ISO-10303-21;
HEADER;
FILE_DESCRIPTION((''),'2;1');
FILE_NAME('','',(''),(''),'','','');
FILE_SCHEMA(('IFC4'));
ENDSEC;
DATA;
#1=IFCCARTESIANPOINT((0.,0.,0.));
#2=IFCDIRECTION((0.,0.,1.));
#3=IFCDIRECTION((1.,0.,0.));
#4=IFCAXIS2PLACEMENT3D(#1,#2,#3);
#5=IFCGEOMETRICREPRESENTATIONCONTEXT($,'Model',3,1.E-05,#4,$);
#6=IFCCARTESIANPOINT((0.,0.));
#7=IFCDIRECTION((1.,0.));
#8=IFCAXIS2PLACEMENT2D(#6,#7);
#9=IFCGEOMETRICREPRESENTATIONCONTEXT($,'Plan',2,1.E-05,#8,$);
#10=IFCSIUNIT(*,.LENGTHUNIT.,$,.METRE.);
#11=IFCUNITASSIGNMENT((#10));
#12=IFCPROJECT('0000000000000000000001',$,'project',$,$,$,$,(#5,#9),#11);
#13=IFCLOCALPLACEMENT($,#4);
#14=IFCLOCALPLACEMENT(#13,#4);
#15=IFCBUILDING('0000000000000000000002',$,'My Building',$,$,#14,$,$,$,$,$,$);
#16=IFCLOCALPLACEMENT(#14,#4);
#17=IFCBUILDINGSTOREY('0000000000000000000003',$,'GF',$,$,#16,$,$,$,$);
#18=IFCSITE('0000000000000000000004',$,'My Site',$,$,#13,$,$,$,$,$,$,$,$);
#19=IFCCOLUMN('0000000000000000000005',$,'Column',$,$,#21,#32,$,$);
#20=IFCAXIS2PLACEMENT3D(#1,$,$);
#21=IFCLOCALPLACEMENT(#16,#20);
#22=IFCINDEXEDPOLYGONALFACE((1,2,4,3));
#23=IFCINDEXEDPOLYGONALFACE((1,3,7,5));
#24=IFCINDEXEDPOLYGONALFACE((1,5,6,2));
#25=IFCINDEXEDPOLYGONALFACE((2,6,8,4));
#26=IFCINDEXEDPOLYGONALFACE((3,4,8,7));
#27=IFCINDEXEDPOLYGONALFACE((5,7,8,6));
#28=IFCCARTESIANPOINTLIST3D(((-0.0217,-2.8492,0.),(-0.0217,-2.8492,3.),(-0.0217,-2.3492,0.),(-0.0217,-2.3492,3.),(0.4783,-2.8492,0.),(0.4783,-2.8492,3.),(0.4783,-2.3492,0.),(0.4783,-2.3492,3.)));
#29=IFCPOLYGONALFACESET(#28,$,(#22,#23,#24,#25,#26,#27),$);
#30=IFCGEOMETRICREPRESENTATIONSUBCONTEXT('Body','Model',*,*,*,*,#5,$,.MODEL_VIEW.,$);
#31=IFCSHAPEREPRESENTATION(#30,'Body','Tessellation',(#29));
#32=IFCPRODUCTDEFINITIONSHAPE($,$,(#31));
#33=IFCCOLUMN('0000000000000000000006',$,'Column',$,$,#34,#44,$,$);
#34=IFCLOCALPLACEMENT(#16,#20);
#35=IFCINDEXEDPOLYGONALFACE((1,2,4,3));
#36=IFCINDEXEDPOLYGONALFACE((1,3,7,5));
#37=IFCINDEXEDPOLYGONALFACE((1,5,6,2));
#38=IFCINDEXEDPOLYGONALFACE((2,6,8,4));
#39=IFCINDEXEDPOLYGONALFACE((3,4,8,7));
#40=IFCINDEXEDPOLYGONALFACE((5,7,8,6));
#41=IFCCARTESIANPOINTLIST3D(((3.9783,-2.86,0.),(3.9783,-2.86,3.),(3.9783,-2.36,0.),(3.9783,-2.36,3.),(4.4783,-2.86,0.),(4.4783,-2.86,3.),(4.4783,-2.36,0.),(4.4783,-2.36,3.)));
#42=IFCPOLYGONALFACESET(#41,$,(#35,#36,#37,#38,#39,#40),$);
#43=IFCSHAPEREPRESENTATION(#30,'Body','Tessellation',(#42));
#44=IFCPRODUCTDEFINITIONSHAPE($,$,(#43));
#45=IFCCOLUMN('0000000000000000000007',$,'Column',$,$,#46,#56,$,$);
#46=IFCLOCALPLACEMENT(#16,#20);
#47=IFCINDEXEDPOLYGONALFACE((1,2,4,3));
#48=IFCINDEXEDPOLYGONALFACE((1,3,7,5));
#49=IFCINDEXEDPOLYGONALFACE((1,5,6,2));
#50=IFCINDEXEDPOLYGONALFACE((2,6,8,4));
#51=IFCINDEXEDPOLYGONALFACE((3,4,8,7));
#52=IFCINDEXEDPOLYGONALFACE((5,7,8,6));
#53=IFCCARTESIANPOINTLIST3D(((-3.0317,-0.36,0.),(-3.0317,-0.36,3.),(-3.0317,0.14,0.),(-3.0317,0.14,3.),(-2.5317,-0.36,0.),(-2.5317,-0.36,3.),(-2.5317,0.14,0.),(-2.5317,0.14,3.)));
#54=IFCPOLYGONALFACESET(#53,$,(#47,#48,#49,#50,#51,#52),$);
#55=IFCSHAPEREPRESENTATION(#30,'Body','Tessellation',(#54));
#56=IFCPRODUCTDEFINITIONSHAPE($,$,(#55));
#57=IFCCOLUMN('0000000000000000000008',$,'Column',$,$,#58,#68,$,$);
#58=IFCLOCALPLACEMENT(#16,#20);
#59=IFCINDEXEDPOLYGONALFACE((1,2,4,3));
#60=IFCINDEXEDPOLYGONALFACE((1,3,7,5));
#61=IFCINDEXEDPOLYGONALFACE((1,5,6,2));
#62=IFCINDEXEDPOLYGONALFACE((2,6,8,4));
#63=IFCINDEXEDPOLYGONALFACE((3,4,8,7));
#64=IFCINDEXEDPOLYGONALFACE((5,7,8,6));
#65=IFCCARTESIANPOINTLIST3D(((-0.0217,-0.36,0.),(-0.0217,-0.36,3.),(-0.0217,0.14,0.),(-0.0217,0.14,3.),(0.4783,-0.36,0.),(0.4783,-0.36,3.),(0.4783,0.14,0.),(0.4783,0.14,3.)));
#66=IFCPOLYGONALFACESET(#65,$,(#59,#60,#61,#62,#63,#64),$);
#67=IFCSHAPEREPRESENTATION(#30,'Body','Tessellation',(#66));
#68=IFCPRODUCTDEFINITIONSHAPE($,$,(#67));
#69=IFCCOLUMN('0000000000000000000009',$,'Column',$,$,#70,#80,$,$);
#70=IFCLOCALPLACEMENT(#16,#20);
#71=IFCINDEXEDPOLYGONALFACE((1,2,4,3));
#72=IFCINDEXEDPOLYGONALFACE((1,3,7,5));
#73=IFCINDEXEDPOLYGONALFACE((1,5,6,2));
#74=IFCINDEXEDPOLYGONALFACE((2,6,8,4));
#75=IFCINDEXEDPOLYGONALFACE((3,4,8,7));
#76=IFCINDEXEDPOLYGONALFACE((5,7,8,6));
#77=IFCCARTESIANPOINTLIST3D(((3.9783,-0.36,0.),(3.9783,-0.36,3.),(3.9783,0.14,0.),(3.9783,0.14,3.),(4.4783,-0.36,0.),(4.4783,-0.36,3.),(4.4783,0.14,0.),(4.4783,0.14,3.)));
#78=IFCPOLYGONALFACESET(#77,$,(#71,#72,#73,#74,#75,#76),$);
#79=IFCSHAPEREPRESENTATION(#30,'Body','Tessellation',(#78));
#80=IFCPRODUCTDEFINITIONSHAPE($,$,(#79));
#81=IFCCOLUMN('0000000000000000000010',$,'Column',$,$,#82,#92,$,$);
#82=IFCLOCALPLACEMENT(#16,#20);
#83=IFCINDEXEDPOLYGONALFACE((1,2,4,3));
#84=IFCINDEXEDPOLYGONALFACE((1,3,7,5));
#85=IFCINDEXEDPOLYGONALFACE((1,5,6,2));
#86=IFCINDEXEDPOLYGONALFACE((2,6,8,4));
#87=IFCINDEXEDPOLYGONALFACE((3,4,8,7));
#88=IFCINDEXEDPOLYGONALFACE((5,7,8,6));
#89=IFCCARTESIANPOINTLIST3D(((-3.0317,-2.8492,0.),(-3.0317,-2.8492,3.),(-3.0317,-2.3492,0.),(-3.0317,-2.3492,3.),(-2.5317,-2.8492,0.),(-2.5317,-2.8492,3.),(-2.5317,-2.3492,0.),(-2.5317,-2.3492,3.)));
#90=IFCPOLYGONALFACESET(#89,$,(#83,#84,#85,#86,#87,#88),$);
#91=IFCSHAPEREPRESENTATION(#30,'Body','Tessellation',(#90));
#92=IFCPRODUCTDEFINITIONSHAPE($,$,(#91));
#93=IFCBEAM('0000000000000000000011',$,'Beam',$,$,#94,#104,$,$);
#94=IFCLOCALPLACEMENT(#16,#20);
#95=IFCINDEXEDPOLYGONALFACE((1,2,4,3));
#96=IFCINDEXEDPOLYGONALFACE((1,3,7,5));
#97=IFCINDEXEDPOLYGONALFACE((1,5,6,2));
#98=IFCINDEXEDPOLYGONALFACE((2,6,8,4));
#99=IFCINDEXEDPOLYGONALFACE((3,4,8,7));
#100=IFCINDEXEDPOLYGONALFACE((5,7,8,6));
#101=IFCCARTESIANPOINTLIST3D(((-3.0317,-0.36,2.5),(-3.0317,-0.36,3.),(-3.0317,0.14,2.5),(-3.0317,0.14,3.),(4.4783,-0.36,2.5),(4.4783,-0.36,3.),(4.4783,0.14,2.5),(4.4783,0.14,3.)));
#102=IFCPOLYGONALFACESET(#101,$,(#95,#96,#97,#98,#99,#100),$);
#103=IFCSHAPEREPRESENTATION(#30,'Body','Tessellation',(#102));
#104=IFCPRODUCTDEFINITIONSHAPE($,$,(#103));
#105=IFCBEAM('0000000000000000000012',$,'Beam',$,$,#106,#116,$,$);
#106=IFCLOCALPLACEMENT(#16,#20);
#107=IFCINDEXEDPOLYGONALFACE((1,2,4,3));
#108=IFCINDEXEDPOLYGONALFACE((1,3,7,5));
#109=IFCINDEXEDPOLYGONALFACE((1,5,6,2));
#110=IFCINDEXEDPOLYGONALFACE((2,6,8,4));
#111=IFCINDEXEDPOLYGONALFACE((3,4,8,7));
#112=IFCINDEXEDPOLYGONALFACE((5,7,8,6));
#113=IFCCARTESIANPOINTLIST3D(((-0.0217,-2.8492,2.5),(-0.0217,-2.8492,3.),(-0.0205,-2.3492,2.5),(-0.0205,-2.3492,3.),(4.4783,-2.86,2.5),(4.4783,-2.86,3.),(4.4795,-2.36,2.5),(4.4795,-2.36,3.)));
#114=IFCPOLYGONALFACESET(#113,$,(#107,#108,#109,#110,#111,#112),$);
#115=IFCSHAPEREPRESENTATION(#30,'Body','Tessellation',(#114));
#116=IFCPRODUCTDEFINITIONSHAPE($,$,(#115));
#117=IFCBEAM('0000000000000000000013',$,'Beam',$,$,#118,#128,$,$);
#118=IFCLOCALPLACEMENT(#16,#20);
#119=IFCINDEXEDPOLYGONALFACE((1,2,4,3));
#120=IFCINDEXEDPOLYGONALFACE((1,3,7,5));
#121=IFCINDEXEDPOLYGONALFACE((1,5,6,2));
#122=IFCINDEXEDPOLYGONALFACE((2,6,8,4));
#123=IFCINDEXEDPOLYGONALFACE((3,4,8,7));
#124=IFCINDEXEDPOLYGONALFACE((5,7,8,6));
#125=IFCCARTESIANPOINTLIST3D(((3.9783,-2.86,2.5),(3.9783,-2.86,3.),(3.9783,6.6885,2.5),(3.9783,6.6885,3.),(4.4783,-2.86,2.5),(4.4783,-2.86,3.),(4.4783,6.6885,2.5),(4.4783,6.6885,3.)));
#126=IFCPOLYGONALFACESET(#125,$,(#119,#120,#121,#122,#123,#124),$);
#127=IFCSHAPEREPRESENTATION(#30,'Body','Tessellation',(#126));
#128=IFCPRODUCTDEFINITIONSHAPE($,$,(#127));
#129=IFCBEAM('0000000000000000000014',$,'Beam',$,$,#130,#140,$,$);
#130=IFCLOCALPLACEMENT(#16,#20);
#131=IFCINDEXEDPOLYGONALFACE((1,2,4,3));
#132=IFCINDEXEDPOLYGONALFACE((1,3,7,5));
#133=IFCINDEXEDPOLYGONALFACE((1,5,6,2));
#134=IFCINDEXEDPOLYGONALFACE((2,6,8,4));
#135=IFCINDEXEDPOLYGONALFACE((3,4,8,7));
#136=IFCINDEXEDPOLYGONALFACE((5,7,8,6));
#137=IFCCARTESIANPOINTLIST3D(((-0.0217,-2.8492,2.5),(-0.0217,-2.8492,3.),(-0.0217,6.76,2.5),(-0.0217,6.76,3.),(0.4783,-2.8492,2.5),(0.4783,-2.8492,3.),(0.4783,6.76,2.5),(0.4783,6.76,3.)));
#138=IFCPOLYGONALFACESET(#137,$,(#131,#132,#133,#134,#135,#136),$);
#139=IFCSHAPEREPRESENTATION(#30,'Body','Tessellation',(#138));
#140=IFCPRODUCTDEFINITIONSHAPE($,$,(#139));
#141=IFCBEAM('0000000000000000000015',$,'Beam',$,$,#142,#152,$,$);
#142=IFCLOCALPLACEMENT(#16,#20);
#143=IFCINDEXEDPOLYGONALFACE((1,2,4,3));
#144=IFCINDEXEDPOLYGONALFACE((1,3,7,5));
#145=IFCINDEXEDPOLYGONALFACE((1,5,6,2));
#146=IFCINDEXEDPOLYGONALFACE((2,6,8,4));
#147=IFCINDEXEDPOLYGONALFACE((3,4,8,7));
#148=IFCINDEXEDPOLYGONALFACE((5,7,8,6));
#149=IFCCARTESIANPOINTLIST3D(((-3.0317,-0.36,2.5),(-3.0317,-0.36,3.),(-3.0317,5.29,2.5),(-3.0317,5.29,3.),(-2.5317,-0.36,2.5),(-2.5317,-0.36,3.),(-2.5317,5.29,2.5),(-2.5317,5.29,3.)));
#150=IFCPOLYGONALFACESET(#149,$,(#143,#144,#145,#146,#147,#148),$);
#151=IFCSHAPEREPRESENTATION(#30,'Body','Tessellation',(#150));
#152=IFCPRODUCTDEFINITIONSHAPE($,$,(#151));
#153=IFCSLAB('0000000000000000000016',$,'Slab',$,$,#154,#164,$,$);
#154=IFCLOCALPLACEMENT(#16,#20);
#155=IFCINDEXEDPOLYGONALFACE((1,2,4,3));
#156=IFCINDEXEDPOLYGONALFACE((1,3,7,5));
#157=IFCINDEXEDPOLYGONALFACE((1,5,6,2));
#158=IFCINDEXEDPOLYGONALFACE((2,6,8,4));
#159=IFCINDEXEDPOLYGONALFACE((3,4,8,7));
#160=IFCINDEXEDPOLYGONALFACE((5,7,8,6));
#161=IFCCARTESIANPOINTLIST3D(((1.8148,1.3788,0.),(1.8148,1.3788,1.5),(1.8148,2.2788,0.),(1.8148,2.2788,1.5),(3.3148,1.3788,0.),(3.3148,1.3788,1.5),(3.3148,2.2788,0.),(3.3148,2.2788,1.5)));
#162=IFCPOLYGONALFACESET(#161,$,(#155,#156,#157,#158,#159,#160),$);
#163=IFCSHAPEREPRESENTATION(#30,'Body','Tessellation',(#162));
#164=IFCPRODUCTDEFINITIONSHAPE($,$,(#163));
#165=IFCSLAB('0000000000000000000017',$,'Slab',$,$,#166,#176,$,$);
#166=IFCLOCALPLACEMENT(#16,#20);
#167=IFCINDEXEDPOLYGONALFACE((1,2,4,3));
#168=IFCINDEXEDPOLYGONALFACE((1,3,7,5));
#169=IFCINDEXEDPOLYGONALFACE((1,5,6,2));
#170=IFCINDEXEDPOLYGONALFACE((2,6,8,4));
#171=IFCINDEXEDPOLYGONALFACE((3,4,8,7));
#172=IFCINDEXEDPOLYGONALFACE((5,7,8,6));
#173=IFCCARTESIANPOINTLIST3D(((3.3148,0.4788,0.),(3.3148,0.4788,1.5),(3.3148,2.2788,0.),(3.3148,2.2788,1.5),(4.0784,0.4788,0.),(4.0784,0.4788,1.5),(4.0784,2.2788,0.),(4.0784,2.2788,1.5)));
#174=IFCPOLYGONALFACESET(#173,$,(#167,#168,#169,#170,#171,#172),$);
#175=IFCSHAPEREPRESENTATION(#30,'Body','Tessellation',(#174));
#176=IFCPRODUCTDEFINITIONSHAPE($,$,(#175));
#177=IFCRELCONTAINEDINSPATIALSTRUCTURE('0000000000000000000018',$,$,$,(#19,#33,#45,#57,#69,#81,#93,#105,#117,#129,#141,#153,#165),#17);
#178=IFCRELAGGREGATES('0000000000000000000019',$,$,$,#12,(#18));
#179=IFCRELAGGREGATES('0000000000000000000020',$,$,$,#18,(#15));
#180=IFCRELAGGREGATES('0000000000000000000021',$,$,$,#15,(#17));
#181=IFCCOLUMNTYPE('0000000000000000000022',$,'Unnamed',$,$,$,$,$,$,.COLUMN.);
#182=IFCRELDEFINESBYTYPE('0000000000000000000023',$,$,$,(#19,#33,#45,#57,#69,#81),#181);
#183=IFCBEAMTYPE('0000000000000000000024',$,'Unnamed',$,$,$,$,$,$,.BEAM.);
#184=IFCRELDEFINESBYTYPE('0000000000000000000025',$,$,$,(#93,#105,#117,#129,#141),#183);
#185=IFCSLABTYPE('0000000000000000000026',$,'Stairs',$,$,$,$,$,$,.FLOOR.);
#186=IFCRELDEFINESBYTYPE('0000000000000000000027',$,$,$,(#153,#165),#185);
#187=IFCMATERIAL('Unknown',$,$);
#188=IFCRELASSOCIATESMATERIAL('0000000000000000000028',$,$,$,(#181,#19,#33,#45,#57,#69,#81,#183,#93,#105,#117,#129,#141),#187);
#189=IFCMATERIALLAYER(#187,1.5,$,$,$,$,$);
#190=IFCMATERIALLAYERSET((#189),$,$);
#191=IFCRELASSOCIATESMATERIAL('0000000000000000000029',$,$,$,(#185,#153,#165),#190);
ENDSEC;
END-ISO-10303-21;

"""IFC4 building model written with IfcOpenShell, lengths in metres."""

from ifc_helpers import new_model, si_unit, frame, origin_with_axes, origin_2d_with_axis, place, context, subcontext, project, spatial, indexed_curve, outline, extrude, material, layer, layer_set, layer_usage, material_profile, profile_set, profile_usage, type_object, element, save


model = new_model("IFC4")

# Units and contexts
model_context = context("Model", 3, precision=1e-05, world=origin_with_axes())
plan_context = context("Plan", 2, precision=1e-05, world=origin_2d_with_axis())
body_context_1 = subcontext(model_context, "Body", "Model", "MODEL_VIEW")
ifc_project = project(units=[si_unit("LENGTHUNIT", "METRE")], contexts=[model_context, plan_context])

# Site, building, storey
site_placement = place(None, origin_with_axes())
site = spatial("IfcSite", under=ifc_project, at=site_placement, Name="My Site")
building_placement = place(site_placement, origin_with_axes())
building = spatial("IfcBuilding", under=site, at=building_placement, Name="My Building")
storey_placement = place(building_placement, origin_with_axes())
storey = spatial("IfcBuildingStorey", under=building, at=storey_placement, Name="GF")

# Columns
ifc_material = material(Name="Unknown")
ifc_material_profile_1 = material_profile(ifc_material, outline(indexed_curve([(-0.25, -0.25), (0.25, -0.25), (0.25, 0.25), (-0.25, 0.25), (-0.25, -0.25)])))
ifc_profile_set_1 = profile_set([ifc_material_profile_1])
ifc_profile_usage_1 = profile_usage(ifc_profile_set_1, cardinal=5)
column_type = type_object("IfcColumnType", Name="Unnamed", PredefinedType="COLUMN", material=ifc_profile_set_1)
column_1_placement = place(storey_placement, frame((0.2283, -2.5992, 0.0), z_axis=(0.0, 0.0, 1.0), x_axis=(1.0, 0.0, 0.0)))
element("IfcColumn", 1, at=column_1_placement, inside=storey, type_object=column_type, material=ifc_profile_usage_1, Name="Column", context=body_context_1, shape_type="SweptSolid", body=[
    extrude(outline(indexed_curve([(-0.25, -0.25), (0.25, -0.25), (0.25, 0.25), (-0.25, 0.25), (-0.25, -0.25)])), origin_with_axes(), (0.0, 0.0, 1.0), 3.0),
])
ifc_profile_usage_2 = profile_usage(ifc_profile_set_1, cardinal=5)
column_2_placement = place(storey_placement, frame((4.2283, -2.61, 0.0), z_axis=(0.0, 0.0, 1.0), x_axis=(1.0, 0.0, 0.0)))
element("IfcColumn", 2, at=column_2_placement, inside=storey, type_object=column_type, material=ifc_profile_usage_2, Name="Column", context=body_context_1, shape_type="SweptSolid", body=[
    extrude(outline(indexed_curve([(-0.25, -0.25), (0.25, -0.25), (0.25, 0.25), (-0.25, 0.25), (-0.25, -0.25)])), origin_with_axes(), (0.0, 0.0, 1.0), 3.0),
])
ifc_profile_usage_3 = profile_usage(ifc_profile_set_1, cardinal=5)
column_3_placement = place(storey_placement, frame((-2.7817, -0.11, 0.0), z_axis=(0.0, 0.0, 1.0), x_axis=(1.0, 0.0, 0.0)))
element("IfcColumn", 3, at=column_3_placement, inside=storey, type_object=column_type, material=ifc_profile_usage_3, Name="Column", context=body_context_1, shape_type="SweptSolid", body=[
    extrude(outline(indexed_curve([(-0.25, -0.25), (0.25, -0.25), (0.25, 0.25), (-0.25, 0.25), (-0.25, -0.25)])), origin_with_axes(), (0.0, 0.0, 1.0), 3.0),
])
ifc_profile_usage_4 = profile_usage(ifc_profile_set_1, cardinal=5)
column_4_placement = place(storey_placement, frame((0.2283, -0.11, 0.0), z_axis=(0.0, 0.0, 1.0), x_axis=(1.0, 0.0, 0.0)))
element("IfcColumn", 4, at=column_4_placement, inside=storey, type_object=column_type, material=ifc_profile_usage_4, Name="Column", context=body_context_1, shape_type="SweptSolid", body=[
    extrude(outline(indexed_curve([(-0.25, -0.25), (0.25, -0.25), (0.25, 0.25), (-0.25, 0.25), (-0.25, -0.25)])), origin_with_axes(), (0.0, 0.0, 1.0), 3.0),
])
ifc_profile_usage_5 = profile_usage(ifc_profile_set_1, cardinal=5)
column_5_placement = place(storey_placement, frame((4.2283, -0.11, 0.0), z_axis=(0.0, 0.0, 1.0), x_axis=(1.0, 0.0, 0.0)))
element("IfcColumn", 5, at=column_5_placement, inside=storey, type_object=column_type, material=ifc_profile_usage_5, Name="Column", context=body_context_1, shape_type="SweptSolid", body=[
    extrude(outline(indexed_curve([(-0.25, -0.25), (0.25, -0.25), (0.25, 0.25), (-0.25, 0.25), (-0.25, -0.25)])), origin_with_axes(), (0.0, 0.0, 1.0), 3.0),
])
ifc_profile_usage_6 = profile_usage(ifc_profile_set_1, cardinal=5)
column_6_placement = place(storey_placement, frame((-2.7817, -2.5992, 0.0), z_axis=(0.0, 0.0, 1.0), x_axis=(1.0, 0.0, 0.0)))
element("IfcColumn", 6, at=column_6_placement, inside=storey, type_object=column_type, material=ifc_profile_usage_6, Name="Column", context=body_context_1, shape_type="SweptSolid", body=[
    extrude(outline(indexed_curve([(-0.25, -0.25), (0.25, -0.25), (0.25, 0.25), (-0.25, 0.25), (-0.25, -0.25)])), origin_with_axes(), (0.0, 0.0, 1.0), 3.0),
])

# Beams
ifc_material_profile_2 = material_profile(ifc_material, outline(indexed_curve([(-0.25, -0.25), (0.25, -0.25), (0.25, 0.25), (-0.25, 0.25), (-0.25, -0.25)])))
ifc_profile_set_2 = profile_set([ifc_material_profile_2])
ifc_profile_usage_7 = profile_usage(ifc_profile_set_2, cardinal=7)
beam_type = type_object("IfcBeamType", Name="Unnamed", PredefinedType="BEAM", material=ifc_profile_set_2)
beam_1_placement = place(storey_placement, frame((4.4783, -0.36, 3.0), z_axis=(-1.0, 0.0, 0.0), x_axis=(0.0, -1.0, 0.0)))
element("IfcBeam", 7, at=beam_1_placement, inside=storey, type_object=beam_type, material=ifc_profile_usage_7, Name="Beam", context=body_context_1, shape_type="SweptSolid", body=[
    extrude(outline(indexed_curve([(-0.25, -0.25), (0.25, -0.25), (0.25, 0.25), (-0.25, 0.25), (-0.25, -0.25)])), frame((-0.25, -0.25, 0.0), z_axis=(0.0, 0.0, 1.0), x_axis=(1.0, 0.0, 0.0)), (0.0, 0.0, 1.0), 7.51),
])
ifc_profile_usage_8 = profile_usage(ifc_profile_set_2, cardinal=7)
beam_2_placement = place(storey_placement, frame((4.4783, -2.86, 3.0), z_axis=(-0.999997, 0.002402, 0.0), x_axis=(-0.002402, -0.999997, 0.0)))
element("IfcBeam", 8, at=beam_2_placement, inside=storey, type_object=beam_type, material=ifc_profile_usage_8, Name="Beam", context=body_context_1, shape_type="SweptSolid", body=[
    extrude(outline(indexed_curve([(-0.25, -0.25), (0.25, -0.25), (0.25, 0.25), (-0.25, 0.25), (-0.25, -0.25)])), frame((-0.25, -0.25, 0.0), z_axis=(0.0, 0.0, 1.0), x_axis=(1.0, 0.0, 0.0)), (0.0, 0.0, 1.0), 4.5),
])
ifc_profile_usage_9 = profile_usage(ifc_profile_set_2, cardinal=9)
beam_3_placement = place(storey_placement, frame((4.4783, -2.86, 3.0), z_axis=(0.0, 1.0, 0.0), x_axis=(-1.0, 0.0, 0.0)))
element("IfcBeam", 9, at=beam_3_placement, inside=storey, type_object=beam_type, material=ifc_profile_usage_9, Name="Beam", context=body_context_1, shape_type="SweptSolid", body=[
    extrude(outline(indexed_curve([(-0.25, -0.25), (0.25, -0.25), (0.25, 0.25), (-0.25, 0.25), (-0.25, -0.25)])), frame((0.25, -0.25, 0.0), z_axis=(0.0, 0.0, 1.0), x_axis=(1.0, 0.0, 0.0)), (0.0, 0.0, 1.0), 9.5485),
])
ifc_profile_usage_10 = profile_usage(ifc_profile_set_2, cardinal=9)
beam_4_placement = place(storey_placement, frame((0.4783, -2.8492, 3.0), z_axis=(0.0, 1.0, 0.0), x_axis=(-1.0, 0.0, 0.0)))
element("IfcBeam", 10, at=beam_4_placement, inside=storey, type_object=beam_type, material=ifc_profile_usage_10, Name="Beam", context=body_context_1, shape_type="SweptSolid", body=[
    extrude(outline(indexed_curve([(-0.25, -0.25), (0.25, -0.25), (0.25, 0.25), (-0.25, 0.25), (-0.25, -0.25)])), frame((0.25, -0.25, 0.0), z_axis=(0.0, 0.0, 1.0), x_axis=(1.0, 0.0, 0.0)), (0.0, 0.0, 1.0), 9.6092),
])
ifc_profile_usage_11 = profile_usage(ifc_profile_set_2, cardinal=9)
beam_5_placement = place(storey_placement, frame((-2.5317, -0.36, 3.0), z_axis=(0.0, 1.0, 0.0), x_axis=(-1.0, 0.0, 0.0)))
element("IfcBeam", 11, at=beam_5_placement, inside=storey, type_object=beam_type, material=ifc_profile_usage_11, Name="Beam", context=body_context_1, shape_type="SweptSolid", body=[
    extrude(outline(indexed_curve([(-0.25, -0.25), (0.25, -0.25), (0.25, 0.25), (-0.25, 0.25), (-0.25, -0.25)])), frame((0.25, -0.25, 0.0), z_axis=(0.0, 0.0, 1.0), x_axis=(1.0, 0.0, 0.0)), (0.0, 0.0, 1.0), 5.65),
])

# Slabs
ifc_layer_1 = layer(ifc_material, 1.5)
ifc_layer_set_1 = layer_set([ifc_layer_1])
ifc_layer_usage_1 = layer_usage(ifc_layer_set_1, "AXIS3", "POSITIVE", -1.5)
slab_type = type_object("IfcSlabType", Name="Stairs", PredefinedType="FLOOR", material=ifc_layer_set_1)
slab_1_placement = place(storey_placement, frame((3.3148, 2.2788, 1.5), z_axis=(0.0, 0.0, 1.0), x_axis=(1.0, 0.0, 0.0)))
element("IfcSlab", 12, at=slab_1_placement, inside=storey, type_object=slab_type, material=ifc_layer_usage_1, Name="Slab", context=body_context_1, shape_type="SweptSolid", body=[
    extrude(outline(indexed_curve([(0.0, 0.0), (0.0, -0.9), (-1.5, -0.9), (-1.5, 0.0), (0.0, 0.0)])), frame((0.0, 0.0, -1.5), z_axis=(0.0, 0.0, 1.0), x_axis=(1.0, 0.0, 0.0)), (0.0, 0.0, 1.0), 1.5),
])
ifc_layer_usage_2 = layer_usage(ifc_layer_set_1, "AXIS3", "POSITIVE", -1.5)
slab_2_placement = place(storey_placement, frame((3.3148, 0.4788, 1.5), z_axis=(0.0, 0.0, 1.0), x_axis=(1.0, 0.0, 0.0)))
element("IfcSlab", 13, at=slab_2_placement, inside=storey, type_object=slab_type, material=ifc_layer_usage_2, Name="Slab", context=body_context_1, shape_type="SweptSolid", body=[
    extrude(outline(indexed_curve([(0.0, 0.0), (0.7636, 0.0), (0.7636, 1.8), (0.0, 1.8), (0.0, 0.0)])), frame((0.0, 0.0, -1.5), z_axis=(0.0, 0.0, 1.0), x_axis=(1.0, 0.0, 0.0)), (0.0, 0.0, 1.0), 1.5),
])

save(model, "model.ifc")
